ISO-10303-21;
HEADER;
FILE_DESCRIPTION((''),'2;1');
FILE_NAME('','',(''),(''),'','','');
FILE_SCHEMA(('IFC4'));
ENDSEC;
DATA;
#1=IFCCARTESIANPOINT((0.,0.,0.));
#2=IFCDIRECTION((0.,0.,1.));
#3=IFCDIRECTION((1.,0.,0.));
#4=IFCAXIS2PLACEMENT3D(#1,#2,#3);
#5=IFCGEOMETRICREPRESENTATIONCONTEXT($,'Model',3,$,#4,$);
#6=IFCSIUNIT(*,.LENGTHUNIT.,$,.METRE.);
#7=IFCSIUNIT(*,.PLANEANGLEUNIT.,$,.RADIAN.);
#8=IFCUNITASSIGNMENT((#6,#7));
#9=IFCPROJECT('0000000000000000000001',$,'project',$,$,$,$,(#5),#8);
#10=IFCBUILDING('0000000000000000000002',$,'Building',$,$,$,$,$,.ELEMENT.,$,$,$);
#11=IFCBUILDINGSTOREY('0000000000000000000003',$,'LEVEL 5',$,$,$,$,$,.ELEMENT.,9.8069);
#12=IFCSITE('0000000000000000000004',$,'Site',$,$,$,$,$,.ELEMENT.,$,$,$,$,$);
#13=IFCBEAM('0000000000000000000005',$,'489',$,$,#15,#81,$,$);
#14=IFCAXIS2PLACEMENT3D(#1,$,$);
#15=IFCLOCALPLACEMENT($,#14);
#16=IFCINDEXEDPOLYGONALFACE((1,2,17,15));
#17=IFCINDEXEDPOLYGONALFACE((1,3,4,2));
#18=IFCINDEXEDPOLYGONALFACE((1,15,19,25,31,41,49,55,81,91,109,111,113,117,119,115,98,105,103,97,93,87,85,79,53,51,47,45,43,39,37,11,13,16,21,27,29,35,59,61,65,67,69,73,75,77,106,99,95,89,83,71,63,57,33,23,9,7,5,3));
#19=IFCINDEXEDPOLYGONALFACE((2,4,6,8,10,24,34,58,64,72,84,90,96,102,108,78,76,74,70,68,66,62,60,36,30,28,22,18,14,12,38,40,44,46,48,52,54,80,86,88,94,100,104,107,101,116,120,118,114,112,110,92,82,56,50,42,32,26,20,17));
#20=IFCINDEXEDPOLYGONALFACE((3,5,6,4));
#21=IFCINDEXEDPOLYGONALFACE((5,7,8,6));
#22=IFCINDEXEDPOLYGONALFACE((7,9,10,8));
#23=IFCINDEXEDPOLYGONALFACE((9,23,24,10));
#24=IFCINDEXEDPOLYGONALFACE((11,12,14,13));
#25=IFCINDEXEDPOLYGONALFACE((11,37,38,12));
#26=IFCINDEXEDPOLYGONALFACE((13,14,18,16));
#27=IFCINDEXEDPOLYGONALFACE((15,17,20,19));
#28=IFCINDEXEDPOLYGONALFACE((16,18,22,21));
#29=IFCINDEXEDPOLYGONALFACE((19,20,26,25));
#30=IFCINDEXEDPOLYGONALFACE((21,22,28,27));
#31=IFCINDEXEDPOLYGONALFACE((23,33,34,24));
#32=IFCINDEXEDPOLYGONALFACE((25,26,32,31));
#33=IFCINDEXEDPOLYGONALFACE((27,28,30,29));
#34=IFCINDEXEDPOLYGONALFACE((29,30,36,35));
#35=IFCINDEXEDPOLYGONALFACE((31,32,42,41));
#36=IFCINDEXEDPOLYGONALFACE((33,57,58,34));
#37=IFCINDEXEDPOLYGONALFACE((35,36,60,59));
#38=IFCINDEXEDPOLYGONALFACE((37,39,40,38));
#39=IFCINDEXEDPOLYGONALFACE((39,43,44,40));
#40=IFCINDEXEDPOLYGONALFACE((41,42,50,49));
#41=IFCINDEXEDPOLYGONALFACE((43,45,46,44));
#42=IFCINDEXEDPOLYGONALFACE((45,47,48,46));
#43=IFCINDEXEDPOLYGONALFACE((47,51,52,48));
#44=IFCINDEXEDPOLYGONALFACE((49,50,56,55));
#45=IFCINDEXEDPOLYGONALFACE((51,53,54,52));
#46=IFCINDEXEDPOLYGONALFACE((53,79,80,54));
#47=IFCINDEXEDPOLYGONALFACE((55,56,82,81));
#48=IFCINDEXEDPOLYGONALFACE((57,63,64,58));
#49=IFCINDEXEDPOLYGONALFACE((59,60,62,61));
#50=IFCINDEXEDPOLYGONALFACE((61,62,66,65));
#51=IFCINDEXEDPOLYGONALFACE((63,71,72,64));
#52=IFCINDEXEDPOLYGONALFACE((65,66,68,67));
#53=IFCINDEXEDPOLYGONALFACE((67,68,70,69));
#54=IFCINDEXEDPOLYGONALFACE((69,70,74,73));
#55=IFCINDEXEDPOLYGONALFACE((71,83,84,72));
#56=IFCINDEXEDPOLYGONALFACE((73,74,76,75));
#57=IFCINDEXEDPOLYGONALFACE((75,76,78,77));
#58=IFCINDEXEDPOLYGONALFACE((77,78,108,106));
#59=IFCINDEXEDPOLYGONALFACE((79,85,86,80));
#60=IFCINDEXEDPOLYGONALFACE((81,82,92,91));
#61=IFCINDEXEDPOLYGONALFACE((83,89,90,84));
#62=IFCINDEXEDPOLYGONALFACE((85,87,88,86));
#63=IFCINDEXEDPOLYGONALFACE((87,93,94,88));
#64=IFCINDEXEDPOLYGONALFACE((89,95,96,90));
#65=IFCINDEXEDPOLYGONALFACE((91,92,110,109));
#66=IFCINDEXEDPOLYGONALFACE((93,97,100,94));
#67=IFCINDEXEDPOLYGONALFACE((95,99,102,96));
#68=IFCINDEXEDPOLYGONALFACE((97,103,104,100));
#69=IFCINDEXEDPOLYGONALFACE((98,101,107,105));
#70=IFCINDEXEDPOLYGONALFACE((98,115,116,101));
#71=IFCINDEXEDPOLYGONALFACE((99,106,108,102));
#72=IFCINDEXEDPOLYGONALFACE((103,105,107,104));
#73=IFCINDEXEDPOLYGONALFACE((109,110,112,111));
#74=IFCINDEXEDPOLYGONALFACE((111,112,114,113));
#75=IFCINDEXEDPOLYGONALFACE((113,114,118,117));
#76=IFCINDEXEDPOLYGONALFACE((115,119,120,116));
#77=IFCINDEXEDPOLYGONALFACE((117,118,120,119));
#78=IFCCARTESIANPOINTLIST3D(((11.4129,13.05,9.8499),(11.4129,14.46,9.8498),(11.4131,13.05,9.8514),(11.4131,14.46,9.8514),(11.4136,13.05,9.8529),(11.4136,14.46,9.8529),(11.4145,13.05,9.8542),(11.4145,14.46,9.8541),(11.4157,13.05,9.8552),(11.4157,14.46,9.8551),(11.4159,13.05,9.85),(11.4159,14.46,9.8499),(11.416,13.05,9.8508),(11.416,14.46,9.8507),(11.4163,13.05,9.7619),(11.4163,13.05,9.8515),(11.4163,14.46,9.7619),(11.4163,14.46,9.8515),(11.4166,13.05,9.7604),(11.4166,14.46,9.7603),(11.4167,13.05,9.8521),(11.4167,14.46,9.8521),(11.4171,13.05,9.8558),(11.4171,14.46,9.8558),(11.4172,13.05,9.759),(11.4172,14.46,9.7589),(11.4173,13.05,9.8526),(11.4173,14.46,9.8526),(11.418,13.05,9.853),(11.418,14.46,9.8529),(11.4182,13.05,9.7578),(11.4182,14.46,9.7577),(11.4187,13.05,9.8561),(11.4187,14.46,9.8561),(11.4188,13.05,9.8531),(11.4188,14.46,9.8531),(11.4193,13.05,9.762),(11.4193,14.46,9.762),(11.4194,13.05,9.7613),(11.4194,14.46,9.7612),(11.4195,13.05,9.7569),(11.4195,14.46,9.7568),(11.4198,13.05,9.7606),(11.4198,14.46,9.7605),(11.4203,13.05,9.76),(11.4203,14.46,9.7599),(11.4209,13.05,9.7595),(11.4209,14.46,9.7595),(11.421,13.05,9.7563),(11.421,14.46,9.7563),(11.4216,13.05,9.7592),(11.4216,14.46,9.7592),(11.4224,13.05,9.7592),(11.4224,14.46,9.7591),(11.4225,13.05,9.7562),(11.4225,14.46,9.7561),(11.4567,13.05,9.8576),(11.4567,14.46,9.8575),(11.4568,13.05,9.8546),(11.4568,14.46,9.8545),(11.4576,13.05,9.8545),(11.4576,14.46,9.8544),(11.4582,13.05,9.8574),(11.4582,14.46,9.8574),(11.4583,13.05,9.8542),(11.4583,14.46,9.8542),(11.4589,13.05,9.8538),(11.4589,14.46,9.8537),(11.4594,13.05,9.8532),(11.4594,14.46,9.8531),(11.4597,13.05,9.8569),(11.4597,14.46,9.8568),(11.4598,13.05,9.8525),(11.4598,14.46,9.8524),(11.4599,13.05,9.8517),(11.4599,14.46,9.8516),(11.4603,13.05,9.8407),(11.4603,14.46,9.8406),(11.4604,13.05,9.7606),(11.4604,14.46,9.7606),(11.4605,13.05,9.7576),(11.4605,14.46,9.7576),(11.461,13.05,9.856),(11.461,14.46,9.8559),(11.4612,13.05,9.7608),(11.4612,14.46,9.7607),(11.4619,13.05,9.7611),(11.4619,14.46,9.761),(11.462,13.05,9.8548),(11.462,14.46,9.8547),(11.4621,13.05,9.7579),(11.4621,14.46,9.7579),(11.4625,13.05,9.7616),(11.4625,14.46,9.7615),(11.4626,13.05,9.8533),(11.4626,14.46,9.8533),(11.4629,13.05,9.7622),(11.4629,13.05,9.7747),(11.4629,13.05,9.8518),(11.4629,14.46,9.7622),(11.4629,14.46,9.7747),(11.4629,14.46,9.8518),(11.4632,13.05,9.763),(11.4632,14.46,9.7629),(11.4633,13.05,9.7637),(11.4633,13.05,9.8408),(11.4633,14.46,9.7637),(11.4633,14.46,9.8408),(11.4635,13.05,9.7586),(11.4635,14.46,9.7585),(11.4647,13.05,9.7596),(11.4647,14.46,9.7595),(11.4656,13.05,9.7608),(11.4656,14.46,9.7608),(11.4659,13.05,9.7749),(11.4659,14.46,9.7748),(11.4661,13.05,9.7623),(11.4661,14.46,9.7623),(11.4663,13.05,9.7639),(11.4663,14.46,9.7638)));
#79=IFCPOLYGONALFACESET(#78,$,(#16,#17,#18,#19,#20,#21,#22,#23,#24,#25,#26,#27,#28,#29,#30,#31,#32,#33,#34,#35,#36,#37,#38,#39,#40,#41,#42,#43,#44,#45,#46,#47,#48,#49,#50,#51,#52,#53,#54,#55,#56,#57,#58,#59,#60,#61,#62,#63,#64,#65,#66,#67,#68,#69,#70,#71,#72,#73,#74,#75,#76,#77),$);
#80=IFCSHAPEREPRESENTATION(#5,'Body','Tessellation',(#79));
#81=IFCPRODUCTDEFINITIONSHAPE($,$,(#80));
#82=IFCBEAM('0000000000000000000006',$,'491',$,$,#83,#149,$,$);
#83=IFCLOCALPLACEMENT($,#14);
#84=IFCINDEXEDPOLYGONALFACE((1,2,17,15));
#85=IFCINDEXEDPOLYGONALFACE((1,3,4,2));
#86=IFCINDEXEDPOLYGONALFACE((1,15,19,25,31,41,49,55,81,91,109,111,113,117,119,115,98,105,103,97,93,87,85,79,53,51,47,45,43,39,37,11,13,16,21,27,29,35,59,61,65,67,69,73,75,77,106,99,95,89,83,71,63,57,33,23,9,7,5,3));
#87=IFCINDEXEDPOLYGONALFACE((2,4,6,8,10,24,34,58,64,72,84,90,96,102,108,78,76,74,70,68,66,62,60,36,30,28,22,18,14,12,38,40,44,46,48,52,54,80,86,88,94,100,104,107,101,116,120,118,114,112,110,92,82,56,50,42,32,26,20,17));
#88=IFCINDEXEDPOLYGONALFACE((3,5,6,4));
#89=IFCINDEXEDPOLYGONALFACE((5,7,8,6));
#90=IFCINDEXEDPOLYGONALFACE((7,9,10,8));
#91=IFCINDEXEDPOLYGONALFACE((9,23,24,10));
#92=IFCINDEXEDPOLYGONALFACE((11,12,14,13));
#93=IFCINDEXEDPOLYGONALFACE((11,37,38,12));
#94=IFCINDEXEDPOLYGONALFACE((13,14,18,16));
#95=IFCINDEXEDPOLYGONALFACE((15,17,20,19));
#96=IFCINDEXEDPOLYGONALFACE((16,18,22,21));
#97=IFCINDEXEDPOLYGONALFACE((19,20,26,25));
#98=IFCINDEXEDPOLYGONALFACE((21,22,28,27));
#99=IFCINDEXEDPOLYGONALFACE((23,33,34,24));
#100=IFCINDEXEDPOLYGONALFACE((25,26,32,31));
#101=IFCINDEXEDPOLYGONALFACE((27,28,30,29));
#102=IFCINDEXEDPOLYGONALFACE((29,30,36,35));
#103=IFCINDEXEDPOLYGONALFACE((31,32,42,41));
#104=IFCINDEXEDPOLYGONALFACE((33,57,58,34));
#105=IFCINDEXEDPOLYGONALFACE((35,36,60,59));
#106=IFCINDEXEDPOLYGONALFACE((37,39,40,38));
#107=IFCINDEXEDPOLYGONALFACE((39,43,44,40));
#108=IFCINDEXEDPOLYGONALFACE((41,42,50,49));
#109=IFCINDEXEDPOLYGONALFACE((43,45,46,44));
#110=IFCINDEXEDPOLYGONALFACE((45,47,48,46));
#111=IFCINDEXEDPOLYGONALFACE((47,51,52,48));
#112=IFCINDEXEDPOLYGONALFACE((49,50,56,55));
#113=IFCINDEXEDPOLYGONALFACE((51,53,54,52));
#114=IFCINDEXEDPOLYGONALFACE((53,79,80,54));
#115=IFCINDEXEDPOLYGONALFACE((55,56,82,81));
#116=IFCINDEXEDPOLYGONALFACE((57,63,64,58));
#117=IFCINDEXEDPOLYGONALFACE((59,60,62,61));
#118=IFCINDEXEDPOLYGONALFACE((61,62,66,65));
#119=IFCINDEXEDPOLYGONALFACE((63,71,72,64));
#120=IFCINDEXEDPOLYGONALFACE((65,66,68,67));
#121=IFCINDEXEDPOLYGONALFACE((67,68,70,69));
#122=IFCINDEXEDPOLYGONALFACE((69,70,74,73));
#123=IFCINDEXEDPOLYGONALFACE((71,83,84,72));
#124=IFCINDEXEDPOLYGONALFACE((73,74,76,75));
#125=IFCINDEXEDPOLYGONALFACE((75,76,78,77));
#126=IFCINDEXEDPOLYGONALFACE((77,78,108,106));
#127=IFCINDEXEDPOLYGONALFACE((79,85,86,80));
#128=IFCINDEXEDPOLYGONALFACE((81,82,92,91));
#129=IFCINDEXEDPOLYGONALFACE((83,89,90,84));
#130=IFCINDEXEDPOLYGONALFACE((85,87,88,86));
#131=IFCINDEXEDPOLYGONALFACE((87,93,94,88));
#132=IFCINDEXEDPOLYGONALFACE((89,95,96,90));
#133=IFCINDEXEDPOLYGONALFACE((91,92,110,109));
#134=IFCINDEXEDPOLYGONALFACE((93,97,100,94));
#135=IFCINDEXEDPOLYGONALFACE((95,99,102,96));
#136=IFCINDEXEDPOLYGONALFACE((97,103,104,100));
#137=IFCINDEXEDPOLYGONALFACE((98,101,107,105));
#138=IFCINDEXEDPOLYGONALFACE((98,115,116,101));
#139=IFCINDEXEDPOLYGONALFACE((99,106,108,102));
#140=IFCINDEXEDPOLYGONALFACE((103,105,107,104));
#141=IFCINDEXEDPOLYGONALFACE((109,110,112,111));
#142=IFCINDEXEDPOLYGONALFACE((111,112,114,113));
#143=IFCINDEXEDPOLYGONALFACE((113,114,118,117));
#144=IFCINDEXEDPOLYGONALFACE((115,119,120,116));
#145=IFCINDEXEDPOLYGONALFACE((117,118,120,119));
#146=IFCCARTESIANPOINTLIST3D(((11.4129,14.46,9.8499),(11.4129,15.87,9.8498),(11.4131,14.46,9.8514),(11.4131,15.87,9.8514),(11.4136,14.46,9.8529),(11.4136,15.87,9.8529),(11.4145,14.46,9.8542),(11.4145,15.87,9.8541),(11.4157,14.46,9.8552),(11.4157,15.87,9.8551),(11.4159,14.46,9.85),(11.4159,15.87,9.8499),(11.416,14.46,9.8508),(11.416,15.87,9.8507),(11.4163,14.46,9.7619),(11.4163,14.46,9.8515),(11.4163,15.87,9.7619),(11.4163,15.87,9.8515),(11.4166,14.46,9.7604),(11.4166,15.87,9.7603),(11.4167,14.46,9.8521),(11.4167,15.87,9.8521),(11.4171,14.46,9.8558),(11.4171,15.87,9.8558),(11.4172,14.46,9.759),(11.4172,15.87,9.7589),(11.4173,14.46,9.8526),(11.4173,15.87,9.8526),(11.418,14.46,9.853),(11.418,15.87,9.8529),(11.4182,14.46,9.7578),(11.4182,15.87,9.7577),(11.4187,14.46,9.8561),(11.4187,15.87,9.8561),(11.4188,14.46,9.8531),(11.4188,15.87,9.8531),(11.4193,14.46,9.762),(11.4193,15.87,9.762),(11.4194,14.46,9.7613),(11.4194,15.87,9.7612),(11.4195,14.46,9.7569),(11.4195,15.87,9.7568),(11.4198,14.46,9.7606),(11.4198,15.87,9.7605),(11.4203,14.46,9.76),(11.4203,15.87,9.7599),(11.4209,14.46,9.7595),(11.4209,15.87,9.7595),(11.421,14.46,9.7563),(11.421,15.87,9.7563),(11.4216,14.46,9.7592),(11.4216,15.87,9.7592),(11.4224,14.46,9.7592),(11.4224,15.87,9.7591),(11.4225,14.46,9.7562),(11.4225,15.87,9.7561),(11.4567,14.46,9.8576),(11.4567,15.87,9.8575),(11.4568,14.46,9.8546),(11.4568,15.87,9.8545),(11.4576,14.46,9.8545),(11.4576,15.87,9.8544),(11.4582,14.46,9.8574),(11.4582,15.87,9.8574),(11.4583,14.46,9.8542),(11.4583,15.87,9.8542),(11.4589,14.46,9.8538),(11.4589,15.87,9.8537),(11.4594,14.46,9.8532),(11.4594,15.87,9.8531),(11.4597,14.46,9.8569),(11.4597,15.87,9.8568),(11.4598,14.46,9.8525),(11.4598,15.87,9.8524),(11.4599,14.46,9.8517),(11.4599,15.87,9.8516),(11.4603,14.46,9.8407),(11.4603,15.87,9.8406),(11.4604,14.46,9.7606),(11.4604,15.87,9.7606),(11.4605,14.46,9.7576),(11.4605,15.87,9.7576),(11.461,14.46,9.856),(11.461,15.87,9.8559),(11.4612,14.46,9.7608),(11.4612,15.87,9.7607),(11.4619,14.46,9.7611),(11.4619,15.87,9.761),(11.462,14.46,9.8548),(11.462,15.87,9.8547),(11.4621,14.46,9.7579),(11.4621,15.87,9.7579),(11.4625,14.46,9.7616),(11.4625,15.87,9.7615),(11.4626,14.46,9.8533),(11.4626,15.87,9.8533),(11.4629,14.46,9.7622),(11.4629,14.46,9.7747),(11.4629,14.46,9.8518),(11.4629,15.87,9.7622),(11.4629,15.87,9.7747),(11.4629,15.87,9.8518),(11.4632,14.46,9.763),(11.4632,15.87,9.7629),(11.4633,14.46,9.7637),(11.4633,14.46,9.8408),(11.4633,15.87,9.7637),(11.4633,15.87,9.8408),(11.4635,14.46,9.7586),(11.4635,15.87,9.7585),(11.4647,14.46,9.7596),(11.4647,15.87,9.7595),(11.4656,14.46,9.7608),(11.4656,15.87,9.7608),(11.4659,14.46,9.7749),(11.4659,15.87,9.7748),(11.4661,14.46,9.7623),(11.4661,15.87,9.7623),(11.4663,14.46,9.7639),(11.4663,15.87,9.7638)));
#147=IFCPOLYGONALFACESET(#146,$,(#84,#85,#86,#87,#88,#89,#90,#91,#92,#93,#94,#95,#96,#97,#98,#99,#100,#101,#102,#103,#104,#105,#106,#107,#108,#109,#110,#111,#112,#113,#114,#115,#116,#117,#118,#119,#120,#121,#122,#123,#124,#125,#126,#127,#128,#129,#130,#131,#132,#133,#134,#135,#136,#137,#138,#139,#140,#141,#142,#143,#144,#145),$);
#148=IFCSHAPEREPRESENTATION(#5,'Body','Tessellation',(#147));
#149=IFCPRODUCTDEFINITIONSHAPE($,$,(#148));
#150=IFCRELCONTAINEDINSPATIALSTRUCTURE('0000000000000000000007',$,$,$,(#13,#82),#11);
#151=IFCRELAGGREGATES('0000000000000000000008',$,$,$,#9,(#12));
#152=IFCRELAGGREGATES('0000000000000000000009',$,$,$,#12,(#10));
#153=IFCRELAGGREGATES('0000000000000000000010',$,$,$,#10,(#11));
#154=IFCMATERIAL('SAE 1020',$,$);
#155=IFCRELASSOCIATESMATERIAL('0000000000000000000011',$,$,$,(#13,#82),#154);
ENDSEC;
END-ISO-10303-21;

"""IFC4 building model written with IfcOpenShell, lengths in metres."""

from ifc_helpers import new_model, si_unit, frame, origin_with_axes, origin_2d_with_axis, place, context, project, spatial, c_section, extrude, material, material_profile, profile_set, profile_usage, element, save


model = new_model("IFC4")

# Units and contexts
model_context = context("Model", 3, world=origin_with_axes())
ifc_project = project(units=[si_unit("LENGTHUNIT", "METRE"), si_unit("PLANEANGLEUNIT", "RADIAN")], contexts=[model_context])

# Site, building, storey
site = spatial("IfcSite", under=ifc_project, Name="Site", CompositionType="ELEMENT")
building = spatial("IfcBuilding", under=site, Name="Building", CompositionType="ELEMENT")
storey = spatial("IfcBuildingStorey", under=building, Name="LEVEL 5", CompositionType="ELEMENT", Elevation=9.8069)

# Beams
ifc_material = material(Name="SAE 1020")
ifc_material_profile_1 = material_profile(ifc_material, c_section(Depth=0.1, Width=0.05, WallThickness=0.003, Girth=0.017, InternalFilletRadius=0.003, at=origin_2d_with_axis()))
ifc_profile_set_1 = profile_set([ifc_material_profile_1])
ifc_profile_usage_1 = profile_usage(ifc_profile_set_1, cardinal=10)
beam_1_placement = place(None, frame((11.4396, 13.05, 9.8069), z_axis=(0.0, 1.0, -0.00003), x_axis=(0.999256, 0.000001, 0.038562)))
element("IfcBeam", 1, at=beam_1_placement, inside=storey, material=ifc_profile_usage_1, Name="489", context=model_context, shape_type="SweptSolid", body=[
    extrude(c_section(Depth=0.1, Width=0.05, WallThickness=0.003, Girth=0.017, InternalFilletRadius=0.003, at=origin_2d_with_axis()), origin_with_axes(), (0.0, 0.0, 1.0), 1.41),
])
ifc_material_profile_2 = material_profile(ifc_material, c_section(Depth=0.1, Width=0.05, WallThickness=0.003, Girth=0.017, InternalFilletRadius=0.003, at=origin_2d_with_axis()))
ifc_profile_set_2 = profile_set([ifc_material_profile_2])
ifc_profile_usage_2 = profile_usage(ifc_profile_set_2, cardinal=10)
beam_2_placement = place(None, frame((11.4396, 14.46, 9.8069), z_axis=(0.0, 1.0, -0.00003), x_axis=(0.999256, 0.000001, 0.038562)))
element("IfcBeam", 2, at=beam_2_placement, inside=storey, material=ifc_profile_usage_2, Name="491", context=model_context, shape_type="SweptSolid", body=[
    extrude(c_section(Depth=0.1, Width=0.05, WallThickness=0.003, Girth=0.017, InternalFilletRadius=0.003, at=origin_2d_with_axis()), origin_with_axes(), (0.0, 0.0, 1.0), 1.41),
])

save(model, "model.ifc")
